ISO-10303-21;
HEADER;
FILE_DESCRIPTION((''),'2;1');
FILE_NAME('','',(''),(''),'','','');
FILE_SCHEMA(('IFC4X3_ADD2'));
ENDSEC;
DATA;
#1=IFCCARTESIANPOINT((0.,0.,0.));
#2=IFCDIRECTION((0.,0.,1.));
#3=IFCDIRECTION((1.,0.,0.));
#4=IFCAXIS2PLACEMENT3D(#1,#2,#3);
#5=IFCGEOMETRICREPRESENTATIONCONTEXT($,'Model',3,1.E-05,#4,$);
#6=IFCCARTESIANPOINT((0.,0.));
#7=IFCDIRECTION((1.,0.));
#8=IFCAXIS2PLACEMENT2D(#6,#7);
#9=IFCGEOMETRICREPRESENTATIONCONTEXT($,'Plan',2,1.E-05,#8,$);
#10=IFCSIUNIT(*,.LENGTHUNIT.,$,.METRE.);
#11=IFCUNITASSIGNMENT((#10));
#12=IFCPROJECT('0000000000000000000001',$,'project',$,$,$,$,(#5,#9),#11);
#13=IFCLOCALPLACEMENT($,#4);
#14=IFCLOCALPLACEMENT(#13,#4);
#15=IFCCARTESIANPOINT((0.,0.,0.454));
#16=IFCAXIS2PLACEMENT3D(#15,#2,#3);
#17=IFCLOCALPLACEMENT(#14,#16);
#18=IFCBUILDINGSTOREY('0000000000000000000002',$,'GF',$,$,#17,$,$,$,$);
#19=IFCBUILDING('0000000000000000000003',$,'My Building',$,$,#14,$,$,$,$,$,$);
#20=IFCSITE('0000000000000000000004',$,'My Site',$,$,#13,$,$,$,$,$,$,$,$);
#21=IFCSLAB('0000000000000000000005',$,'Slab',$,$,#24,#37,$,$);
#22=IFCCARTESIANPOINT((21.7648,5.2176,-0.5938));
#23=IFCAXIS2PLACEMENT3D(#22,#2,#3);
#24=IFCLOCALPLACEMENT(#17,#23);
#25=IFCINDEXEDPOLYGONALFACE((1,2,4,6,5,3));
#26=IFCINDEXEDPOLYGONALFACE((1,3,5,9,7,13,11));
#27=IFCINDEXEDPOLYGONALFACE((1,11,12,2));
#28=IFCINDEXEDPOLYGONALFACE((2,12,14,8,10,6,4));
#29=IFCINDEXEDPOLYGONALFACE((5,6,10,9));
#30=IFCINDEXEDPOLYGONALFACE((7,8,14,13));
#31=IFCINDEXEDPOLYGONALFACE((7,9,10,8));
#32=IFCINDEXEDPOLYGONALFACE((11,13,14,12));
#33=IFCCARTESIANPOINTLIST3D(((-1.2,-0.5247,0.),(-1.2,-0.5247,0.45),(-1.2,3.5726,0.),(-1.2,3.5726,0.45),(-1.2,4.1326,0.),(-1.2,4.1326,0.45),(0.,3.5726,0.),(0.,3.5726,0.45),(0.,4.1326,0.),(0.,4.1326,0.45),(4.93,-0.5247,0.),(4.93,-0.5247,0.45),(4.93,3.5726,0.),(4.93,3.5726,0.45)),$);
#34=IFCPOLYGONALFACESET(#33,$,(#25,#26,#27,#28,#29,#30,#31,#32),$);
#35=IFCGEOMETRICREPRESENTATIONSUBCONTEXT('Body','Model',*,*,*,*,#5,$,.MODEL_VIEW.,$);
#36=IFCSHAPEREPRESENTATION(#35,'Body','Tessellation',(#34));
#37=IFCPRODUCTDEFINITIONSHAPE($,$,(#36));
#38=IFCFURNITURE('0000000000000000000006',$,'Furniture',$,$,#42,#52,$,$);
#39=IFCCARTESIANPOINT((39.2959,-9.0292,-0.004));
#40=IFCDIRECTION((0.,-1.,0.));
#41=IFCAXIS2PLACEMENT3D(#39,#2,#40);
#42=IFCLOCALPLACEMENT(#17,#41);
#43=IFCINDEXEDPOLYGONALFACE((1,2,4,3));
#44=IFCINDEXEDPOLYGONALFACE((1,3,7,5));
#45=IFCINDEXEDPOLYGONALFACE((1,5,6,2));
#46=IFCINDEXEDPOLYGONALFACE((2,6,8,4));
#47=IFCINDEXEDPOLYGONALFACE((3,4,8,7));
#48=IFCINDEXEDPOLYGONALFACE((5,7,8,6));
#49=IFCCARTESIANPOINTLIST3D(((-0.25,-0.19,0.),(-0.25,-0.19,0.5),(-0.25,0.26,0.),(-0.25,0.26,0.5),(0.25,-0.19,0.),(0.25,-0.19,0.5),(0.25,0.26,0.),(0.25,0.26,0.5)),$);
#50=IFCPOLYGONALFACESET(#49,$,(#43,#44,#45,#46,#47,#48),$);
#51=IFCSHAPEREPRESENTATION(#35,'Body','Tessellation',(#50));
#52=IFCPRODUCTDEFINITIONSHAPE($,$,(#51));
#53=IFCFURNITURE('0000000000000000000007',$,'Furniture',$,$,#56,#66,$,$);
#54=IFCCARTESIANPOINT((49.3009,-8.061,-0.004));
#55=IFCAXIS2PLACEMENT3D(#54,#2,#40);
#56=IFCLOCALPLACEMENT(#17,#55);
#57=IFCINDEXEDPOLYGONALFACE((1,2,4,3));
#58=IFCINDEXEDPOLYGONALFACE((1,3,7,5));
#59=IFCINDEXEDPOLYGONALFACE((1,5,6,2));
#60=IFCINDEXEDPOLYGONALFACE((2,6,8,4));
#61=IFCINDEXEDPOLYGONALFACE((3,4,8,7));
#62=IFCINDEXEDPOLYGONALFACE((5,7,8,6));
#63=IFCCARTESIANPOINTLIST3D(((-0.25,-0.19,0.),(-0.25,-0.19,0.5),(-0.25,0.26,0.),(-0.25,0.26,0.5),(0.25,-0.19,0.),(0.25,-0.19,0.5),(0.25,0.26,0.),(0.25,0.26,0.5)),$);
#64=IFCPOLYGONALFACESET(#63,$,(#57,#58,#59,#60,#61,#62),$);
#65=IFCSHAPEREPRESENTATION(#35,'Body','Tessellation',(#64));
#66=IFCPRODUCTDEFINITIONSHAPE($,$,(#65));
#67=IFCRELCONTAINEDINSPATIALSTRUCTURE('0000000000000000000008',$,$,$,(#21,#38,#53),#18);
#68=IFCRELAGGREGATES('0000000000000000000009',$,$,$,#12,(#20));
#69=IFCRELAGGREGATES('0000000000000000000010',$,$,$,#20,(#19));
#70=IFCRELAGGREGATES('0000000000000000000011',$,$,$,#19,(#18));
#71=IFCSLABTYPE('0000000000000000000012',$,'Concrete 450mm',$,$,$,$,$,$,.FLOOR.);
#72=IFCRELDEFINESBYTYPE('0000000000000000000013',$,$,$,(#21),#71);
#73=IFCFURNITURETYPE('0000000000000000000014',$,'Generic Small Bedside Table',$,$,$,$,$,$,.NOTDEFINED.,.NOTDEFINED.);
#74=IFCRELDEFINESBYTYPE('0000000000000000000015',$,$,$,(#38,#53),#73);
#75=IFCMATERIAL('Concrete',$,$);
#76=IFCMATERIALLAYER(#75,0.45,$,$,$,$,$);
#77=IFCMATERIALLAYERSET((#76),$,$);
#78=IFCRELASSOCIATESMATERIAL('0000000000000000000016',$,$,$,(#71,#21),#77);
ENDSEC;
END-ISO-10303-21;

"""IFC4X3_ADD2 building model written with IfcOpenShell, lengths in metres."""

from ifc_helpers import new_model, entity, si_unit, frame, origin_with_axes, origin_2d_with_axis, place, context, subcontext, project, spatial, line, indexed_curve, outline, extrude, shape, source, transform, mapped, material, layer, layer_set, layer_usage, type_object, type_shapes, element, save


model = new_model("IFC4X3_ADD2")

# Units and contexts
model_context = context("Model", 3, precision=1e-05, world=origin_with_axes())
plan_context = context("Plan", 2, precision=1e-05, world=origin_2d_with_axis())
body_context_1 = subcontext(model_context, "Body", "Model", "MODEL_VIEW")
body_context_2 = subcontext(plan_context, "Body", "Plan", "PLAN_VIEW")
ifc_project = project(units=[si_unit("LENGTHUNIT", "METRE")], contexts=[model_context, plan_context])

# Site, building, storey
site_placement = place(None, origin_with_axes())
site = spatial("IfcSite", under=ifc_project, at=site_placement, Name="My Site")
building_placement = place(site_placement, origin_with_axes())
building = spatial("IfcBuilding", under=site, at=building_placement, Name="My Building")
storey_placement = place(building_placement, frame((0.0, 0.0, 0.454), z_axis=(0.0, 0.0, 1.0), x_axis=(1.0, 0.0, 0.0)))
storey = spatial("IfcBuildingStorey", under=building, at=storey_placement, Name="GF")

# Slab
ifc_material_1 = material(Name="Concrete")
ifc_layer = layer(ifc_material_1, 0.45)
ifc_layer_set = layer_set([ifc_layer])
ifc_layer_usage = layer_usage(ifc_layer_set, "AXIS3", "POSITIVE", 0.0)
slab_type = type_object("IfcSlabType", Name="Concrete 450mm", PredefinedType="FLOOR", material=ifc_layer_set)
slab_placement = place(storey_placement, frame((21.7648, 5.2176, -0.5938), z_axis=(0.0, 0.0, 1.0), x_axis=(1.0, 0.0, 0.0)))
element("IfcSlab", 1, at=slab_placement, inside=storey, type_object=slab_type, material=ifc_layer_usage, Name="Slab", context=body_context_1, shape_type="SweptSolid", body=[
    extrude(outline(indexed_curve([(4.93, -0.5247), (-1.2, -0.5247), (-1.2, 3.5726), (-1.2, 4.1326), (0.0, 4.1326), (0.0, 3.5726), (4.93, 3.5726)], segments=[line(3, 2), line(2, 1), line(1, 7), line(7, 6), line(6, 5), line(5, 4), line(4, 3)], self_intersect=False)), None, (0.0, 0.0, 1.0), 0.45),
])

# Furniture
furniture_type_1 = type_object("IfcFurnitureType", Name="Generic Small Bedside Table", AssemblyPlace="NOTDEFINED", PredefinedType="NOTDEFINED")
shared_shape_1 = source(origin_with_axes(), body_context_1, "Body", "SweptSolid", [
    extrude(outline(indexed_curve([(0.5, 0.45), (0.5, 0.0), (0.0, 0.0), (0.0, 0.45)], segments=[line(4, 1), line(1, 2), line(2, 3), line(3, 4)], self_intersect=False)), frame((-0.25, -0.19, 0.0), z_axis=(0.0, 0.0, 1.0), x_axis=(1.0, 0.0, 0.0)), (0.0, 0.0, 1.0), 0.5),
])
shared_shape_2 = source(origin_with_axes(), body_context_2, "Body", "Annotation2D", [
    entity("IfcGeometricCurveSet", [entity("IfcIndexedPolyCurve", entity("IfcCartesianPointList2D", [[-0.25, -0.19], [0.25, -0.19], [0.25, 0.26], [-0.25, 0.26]]), [entity("IfcLineIndex", [1, 2]), entity("IfcLineIndex", [2, 3]), entity("IfcLineIndex", [3, 4]), entity("IfcLineIndex", [4, 1])])]),
])
type_shapes(furniture_type_1, [shared_shape_1, shared_shape_2])
for number, where, z_axis, x_axis, name in (
    (2, (39.2959, -9.0292, -0.004), (0.0, 0.0, 1.0), (0.0, -1.0, 0.0), "Furniture"),
    (3, (49.3009, -8.061, -0.004), (0.0, 0.0, 1.0), (0.0, -1.0, 0.0), "Furniture"),
):
    element("IfcFurniture", number, at=place(storey_placement, frame(where, z_axis=z_axis, x_axis=x_axis)), inside=storey, type_object=furniture_type_1, Name=name, shapes=[
        shape(body_context_1, "Body", "MappedRepresentation", [mapped(shared_shape_1, transform((0.0, 0.0, 0.0), x_axis=(1.0, 0.0, 0.0), y_axis=(0.0, 1.0, 0.0), z_axis=(0.0, 0.0, 1.0), scale=1.0))]),
        shape(body_context_2, "Body", "MappedRepresentation", [mapped(shared_shape_2, transform((0.0, 0.0, 0.0), x_axis=(1.0, 0.0, 0.0), y_axis=(0.0, 1.0, 0.0), z_axis=(0.0, 0.0, 1.0), scale=1.0))]),
    ])

save(model, "model.ifc")
